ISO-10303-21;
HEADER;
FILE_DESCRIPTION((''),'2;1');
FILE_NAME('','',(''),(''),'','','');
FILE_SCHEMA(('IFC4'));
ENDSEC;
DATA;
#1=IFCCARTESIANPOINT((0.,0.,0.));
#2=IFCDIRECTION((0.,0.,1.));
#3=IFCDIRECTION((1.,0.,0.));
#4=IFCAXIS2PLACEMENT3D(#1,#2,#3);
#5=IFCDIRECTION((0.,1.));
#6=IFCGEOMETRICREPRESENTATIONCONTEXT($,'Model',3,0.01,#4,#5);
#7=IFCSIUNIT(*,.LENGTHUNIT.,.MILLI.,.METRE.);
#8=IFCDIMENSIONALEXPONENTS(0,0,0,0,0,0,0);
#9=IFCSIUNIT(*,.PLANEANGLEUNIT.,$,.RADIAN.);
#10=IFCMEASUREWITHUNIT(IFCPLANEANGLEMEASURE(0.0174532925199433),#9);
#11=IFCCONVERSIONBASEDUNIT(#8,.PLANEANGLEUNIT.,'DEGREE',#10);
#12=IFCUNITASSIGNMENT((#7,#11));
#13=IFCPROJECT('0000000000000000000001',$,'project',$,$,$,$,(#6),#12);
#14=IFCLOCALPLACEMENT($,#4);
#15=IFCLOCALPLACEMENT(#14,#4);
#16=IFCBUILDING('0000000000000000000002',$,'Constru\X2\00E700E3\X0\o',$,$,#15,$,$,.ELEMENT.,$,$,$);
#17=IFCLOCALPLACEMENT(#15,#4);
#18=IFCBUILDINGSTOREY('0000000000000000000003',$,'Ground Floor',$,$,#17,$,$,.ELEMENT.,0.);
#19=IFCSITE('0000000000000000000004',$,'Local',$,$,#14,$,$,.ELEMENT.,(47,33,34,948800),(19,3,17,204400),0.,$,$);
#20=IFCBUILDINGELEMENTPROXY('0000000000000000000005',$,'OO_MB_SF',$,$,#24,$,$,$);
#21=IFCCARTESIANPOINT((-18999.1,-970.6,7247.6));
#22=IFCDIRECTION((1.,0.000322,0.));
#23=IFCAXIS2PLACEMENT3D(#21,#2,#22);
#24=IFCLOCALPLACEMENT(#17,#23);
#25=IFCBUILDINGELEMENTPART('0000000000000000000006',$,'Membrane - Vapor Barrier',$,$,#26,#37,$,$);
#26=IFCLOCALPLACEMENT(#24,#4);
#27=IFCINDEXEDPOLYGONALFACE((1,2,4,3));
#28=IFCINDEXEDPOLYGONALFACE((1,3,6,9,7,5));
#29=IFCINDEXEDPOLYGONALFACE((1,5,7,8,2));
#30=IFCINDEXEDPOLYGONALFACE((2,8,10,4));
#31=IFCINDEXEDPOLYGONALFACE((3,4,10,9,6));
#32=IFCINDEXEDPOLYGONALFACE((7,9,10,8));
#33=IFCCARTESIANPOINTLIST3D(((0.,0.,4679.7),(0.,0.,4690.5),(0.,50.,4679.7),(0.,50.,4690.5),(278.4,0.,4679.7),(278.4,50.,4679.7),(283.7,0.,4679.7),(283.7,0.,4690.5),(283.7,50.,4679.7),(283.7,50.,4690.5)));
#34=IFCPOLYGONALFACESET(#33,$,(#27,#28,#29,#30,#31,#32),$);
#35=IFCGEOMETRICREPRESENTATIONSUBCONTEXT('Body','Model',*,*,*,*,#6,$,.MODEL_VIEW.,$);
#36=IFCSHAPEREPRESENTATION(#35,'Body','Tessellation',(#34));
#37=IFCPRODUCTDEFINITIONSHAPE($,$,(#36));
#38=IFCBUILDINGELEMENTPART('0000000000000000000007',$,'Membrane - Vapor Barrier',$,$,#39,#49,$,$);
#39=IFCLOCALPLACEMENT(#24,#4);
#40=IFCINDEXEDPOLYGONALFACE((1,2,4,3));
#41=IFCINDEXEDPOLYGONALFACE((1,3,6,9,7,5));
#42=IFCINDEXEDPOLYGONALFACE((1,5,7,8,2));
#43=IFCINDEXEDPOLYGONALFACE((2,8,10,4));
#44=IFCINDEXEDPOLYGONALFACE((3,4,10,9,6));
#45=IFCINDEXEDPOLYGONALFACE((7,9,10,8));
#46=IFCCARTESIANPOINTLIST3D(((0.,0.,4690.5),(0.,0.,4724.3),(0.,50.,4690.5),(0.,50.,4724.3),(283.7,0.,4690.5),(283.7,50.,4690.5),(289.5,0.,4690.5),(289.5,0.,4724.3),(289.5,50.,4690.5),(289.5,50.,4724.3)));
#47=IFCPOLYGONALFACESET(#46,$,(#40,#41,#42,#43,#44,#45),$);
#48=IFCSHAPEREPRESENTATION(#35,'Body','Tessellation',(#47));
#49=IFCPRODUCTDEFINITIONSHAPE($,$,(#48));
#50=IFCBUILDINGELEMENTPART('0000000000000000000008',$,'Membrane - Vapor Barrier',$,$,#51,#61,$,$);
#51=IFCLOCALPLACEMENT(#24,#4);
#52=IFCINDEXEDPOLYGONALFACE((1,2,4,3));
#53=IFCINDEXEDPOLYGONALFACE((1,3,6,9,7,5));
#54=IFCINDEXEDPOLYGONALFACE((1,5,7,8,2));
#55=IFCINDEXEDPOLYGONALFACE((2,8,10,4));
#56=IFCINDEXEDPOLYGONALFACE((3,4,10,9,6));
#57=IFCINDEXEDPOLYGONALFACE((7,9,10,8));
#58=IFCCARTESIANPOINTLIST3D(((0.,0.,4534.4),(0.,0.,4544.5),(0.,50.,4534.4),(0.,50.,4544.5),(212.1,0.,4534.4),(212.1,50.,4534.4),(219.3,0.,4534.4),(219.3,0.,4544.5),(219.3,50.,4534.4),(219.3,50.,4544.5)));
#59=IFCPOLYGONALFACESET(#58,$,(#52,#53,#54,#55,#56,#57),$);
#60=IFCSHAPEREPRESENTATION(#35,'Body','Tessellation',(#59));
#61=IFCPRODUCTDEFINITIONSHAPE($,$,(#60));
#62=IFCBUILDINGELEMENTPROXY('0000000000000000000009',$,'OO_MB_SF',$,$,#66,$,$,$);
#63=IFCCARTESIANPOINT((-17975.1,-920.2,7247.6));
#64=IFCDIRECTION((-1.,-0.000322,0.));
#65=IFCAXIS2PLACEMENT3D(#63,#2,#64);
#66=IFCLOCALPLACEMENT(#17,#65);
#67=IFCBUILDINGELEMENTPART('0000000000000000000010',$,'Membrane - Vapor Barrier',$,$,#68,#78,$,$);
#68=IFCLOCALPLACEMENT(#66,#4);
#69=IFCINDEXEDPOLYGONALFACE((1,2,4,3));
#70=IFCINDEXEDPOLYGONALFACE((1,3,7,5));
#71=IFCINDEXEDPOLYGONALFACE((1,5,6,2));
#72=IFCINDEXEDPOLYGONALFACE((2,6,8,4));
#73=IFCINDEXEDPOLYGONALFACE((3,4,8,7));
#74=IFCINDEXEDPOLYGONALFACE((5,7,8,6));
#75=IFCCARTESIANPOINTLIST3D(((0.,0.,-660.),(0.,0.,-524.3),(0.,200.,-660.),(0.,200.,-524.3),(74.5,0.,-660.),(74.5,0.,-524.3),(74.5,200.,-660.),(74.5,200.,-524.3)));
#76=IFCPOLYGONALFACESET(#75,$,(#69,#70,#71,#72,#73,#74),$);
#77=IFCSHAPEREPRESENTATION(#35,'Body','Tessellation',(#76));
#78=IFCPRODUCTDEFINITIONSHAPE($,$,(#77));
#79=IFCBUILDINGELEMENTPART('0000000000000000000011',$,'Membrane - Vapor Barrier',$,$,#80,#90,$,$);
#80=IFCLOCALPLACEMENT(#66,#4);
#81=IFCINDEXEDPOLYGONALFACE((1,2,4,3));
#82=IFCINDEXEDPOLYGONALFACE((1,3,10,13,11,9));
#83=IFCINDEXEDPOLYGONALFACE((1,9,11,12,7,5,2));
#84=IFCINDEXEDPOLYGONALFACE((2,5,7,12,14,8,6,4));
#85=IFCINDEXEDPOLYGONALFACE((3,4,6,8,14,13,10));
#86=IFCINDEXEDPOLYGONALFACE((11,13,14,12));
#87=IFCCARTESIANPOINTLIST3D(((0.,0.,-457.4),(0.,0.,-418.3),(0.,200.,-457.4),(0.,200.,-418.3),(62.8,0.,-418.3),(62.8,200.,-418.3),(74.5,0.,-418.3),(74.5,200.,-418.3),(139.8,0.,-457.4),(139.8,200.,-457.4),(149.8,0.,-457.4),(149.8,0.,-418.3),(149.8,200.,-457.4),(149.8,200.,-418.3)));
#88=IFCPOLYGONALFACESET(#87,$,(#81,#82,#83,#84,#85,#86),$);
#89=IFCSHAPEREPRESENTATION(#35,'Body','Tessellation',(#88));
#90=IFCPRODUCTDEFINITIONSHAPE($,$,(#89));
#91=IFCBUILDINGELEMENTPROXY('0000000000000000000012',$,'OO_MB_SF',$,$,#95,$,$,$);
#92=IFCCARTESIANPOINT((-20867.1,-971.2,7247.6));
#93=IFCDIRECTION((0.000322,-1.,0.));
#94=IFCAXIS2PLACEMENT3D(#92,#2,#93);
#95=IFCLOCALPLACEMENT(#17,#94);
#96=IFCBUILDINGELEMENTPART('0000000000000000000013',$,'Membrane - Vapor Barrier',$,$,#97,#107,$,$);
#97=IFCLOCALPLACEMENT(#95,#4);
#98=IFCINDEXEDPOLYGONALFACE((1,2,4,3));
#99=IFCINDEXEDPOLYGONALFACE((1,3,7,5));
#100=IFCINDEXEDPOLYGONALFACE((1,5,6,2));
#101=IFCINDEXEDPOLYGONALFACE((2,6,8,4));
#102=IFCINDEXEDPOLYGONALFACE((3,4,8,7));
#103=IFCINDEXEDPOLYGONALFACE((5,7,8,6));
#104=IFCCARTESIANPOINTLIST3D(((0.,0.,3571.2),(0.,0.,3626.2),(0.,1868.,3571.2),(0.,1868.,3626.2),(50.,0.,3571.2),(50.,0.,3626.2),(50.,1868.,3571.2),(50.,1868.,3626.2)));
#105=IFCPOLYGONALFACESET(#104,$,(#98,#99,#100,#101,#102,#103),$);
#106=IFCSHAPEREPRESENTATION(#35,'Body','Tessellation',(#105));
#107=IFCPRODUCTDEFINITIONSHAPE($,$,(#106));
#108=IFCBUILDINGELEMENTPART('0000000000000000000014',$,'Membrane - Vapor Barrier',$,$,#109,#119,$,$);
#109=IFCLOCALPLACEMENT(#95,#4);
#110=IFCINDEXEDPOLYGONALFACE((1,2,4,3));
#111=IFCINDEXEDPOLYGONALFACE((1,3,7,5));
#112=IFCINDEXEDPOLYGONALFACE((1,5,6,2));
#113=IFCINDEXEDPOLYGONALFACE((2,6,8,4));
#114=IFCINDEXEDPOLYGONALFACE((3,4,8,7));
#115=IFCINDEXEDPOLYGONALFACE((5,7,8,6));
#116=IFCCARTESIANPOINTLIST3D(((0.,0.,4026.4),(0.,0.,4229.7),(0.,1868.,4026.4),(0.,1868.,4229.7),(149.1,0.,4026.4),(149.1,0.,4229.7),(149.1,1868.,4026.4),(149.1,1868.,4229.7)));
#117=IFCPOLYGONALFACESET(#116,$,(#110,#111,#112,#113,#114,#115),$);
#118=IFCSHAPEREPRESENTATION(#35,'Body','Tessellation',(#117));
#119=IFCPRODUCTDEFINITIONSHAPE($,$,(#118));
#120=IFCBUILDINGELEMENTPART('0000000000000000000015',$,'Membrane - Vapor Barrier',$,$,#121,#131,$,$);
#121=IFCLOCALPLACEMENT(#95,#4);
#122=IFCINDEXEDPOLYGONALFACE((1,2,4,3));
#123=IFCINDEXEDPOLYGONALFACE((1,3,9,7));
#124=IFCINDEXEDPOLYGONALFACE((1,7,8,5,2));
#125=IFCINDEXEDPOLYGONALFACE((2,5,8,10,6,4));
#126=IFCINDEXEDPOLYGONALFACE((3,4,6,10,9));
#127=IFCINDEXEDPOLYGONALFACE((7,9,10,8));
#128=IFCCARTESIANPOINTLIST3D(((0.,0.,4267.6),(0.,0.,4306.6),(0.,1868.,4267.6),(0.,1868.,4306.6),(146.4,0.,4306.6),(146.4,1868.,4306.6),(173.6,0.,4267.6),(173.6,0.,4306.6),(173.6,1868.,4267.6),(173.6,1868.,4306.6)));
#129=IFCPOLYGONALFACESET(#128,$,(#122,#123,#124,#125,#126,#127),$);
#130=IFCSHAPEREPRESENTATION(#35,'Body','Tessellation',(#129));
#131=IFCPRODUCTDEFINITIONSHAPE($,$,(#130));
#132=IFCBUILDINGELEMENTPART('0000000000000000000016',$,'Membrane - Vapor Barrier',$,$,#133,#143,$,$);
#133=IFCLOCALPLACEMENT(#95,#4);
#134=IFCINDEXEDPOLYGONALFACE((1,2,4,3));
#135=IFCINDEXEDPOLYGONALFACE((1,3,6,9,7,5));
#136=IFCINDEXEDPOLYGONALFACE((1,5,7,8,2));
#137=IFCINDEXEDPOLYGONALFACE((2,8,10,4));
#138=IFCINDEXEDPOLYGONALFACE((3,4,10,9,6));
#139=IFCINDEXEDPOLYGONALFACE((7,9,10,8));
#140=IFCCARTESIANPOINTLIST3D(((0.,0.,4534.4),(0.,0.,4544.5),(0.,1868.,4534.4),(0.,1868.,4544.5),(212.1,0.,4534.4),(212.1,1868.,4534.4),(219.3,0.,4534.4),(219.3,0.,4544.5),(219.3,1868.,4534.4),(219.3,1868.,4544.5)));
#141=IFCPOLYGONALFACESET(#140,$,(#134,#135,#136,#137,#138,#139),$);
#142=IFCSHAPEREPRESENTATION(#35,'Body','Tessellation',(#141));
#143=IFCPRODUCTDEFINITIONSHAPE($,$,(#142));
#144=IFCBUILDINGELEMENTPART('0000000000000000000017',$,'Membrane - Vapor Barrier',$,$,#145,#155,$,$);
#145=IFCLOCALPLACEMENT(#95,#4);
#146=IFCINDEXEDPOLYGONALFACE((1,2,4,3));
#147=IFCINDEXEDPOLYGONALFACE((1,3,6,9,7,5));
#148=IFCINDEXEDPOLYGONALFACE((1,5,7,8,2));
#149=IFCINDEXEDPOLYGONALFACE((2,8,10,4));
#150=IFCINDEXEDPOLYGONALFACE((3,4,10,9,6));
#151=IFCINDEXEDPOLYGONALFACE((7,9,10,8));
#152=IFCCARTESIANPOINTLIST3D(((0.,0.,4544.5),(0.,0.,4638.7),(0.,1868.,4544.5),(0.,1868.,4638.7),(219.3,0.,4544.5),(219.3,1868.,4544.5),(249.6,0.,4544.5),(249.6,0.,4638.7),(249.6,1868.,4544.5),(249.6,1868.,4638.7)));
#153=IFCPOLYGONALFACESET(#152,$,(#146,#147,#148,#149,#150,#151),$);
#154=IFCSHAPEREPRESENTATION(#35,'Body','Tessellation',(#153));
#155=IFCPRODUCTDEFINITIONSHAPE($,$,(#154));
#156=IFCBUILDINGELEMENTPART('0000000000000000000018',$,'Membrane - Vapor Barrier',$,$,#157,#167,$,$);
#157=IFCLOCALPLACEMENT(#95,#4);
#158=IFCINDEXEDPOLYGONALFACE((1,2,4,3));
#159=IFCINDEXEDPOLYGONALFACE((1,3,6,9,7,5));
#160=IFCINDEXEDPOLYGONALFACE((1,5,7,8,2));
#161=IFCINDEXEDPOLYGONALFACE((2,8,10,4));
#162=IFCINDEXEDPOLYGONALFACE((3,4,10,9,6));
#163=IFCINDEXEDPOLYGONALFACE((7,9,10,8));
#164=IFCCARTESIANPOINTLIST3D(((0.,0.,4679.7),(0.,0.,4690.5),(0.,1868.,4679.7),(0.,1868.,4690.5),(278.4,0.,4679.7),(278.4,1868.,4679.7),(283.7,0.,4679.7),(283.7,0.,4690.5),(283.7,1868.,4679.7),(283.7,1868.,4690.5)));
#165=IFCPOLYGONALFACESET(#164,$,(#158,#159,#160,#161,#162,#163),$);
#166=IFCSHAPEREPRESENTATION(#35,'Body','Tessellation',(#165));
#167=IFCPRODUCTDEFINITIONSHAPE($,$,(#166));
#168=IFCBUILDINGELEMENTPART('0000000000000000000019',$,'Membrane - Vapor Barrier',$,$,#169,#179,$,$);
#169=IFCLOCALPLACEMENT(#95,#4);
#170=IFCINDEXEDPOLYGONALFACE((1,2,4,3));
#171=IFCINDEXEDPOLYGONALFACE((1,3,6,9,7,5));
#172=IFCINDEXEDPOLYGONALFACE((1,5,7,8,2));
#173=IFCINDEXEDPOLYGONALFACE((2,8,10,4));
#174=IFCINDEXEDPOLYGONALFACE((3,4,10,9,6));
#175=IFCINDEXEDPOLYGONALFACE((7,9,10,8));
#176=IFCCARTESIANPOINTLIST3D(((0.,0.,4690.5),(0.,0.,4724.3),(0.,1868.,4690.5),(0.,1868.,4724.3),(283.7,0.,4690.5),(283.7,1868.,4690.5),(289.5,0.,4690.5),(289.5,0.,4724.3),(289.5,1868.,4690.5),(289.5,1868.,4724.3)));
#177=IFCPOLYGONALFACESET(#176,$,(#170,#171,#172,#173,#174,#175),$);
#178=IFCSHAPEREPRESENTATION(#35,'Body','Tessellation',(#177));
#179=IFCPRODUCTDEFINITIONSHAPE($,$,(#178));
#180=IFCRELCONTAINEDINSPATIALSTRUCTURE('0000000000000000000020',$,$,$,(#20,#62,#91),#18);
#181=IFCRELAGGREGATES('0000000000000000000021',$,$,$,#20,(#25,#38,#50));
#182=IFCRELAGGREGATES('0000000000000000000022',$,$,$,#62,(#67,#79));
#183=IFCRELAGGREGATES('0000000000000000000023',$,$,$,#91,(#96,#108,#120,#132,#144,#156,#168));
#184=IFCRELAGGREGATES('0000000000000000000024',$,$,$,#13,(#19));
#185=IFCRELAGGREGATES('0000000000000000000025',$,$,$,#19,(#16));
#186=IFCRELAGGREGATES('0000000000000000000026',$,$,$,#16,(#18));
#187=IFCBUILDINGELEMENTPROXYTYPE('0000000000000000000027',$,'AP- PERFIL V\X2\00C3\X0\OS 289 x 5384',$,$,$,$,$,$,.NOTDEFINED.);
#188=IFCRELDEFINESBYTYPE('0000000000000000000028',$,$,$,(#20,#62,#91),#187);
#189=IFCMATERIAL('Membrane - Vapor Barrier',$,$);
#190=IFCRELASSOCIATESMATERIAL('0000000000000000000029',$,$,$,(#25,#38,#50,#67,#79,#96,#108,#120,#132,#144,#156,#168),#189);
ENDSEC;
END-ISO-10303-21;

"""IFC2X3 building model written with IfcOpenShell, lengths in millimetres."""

from ifc_helpers import new_model, entity, si_unit, converted_unit, direction, frame, origin_with_axes, place, context, subcontext, project, spatial, polyline, outline, extrude, material, type_object, element, aggregate, save


model = new_model("IFC2X3")

# Units and contexts
model_context = context("Model", 3, precision=0.01, world=origin_with_axes(), true_north=direction((0.0, 1.0)))
body_context = subcontext(model_context, "Body", "Model", "MODEL_VIEW")
ifc_project = project(units=[si_unit("LENGTHUNIT", "METRE", prefix="MILLI"), converted_unit("PLANEANGLEUNIT", "DEGREE", entity("IfcPlaneAngleMeasure", 0.0174532925199433), si_unit("PLANEANGLEUNIT", "RADIAN"), dimensions=[0, 0, 0, 0, 0, 0, 0])], contexts=[model_context])

# Site, building, storey
site_placement = place(None, origin_with_axes())
site = spatial("IfcSite", under=ifc_project, at=site_placement, Name="Local", CompositionType="ELEMENT", RefLatitude=(47, 33, 34, 948800), RefLongitude=(19, 3, 17, 204400), RefElevation=0.0)
building_placement = place(site_placement, origin_with_axes())
building = spatial("IfcBuilding", under=site, at=building_placement, Name="Construção", CompositionType="ELEMENT")
storey_placement = place(building_placement, origin_with_axes())
storey = spatial("IfcBuildingStorey", under=building, at=storey_placement, Name="Ground Floor", CompositionType="ELEMENT", Elevation=0.0)

# Building element proxies, building element parts
building_element_proxy_type = type_object("IfcBuildingElementProxyType", Name="AP- PERFIL VÃOS 289 x 5384", PredefinedType="NOTDEFINED")
proxy_1_placement = place(storey_placement, frame((-18999.1, -970.6, 7247.6), z_axis=(0.0, 0.0, 1.0), x_axis=(1.0, 0.000322, 0.0)))
proxy_1 = element("IfcBuildingElementProxy", 1, at=proxy_1_placement, inside=storey, type_object=building_element_proxy_type, Name="OO_MB_SF")
ifc_material = material(Name="Membrane - Vapor Barrier")
building_element_part_1_placement = place(proxy_1_placement, origin_with_axes())
building_element_part_1 = element("IfcBuildingElementPart", 2, at=building_element_part_1_placement, material=ifc_material, Name="Membrane - Vapor Barrier", context=body_context, shape_type="SweptSolid", body=[
    extrude(outline(polyline([(0.0, 4679.7), (278.4, 4679.7), (283.7, 4679.7), (283.7, 4690.5), (0.0, 4690.5), (0.0, 4679.7)])), frame((0.0, 50.0, 0.0), z_axis=(0.0, -1.0, 0.0), x_axis=(1.0, 0.0, 0.0)), (0.0, 0.0, 1.0), 50.0),
])
building_element_part_2_placement = place(proxy_1_placement, origin_with_axes())
building_element_part_2 = element("IfcBuildingElementPart", 3, at=building_element_part_2_placement, material=ifc_material, Name="Membrane - Vapor Barrier", context=body_context, shape_type="SweptSolid", body=[
    extrude(outline(polyline([(0.0, 4690.5), (283.7, 4690.5), (289.5, 4690.5), (289.5, 4724.3), (0.0, 4724.3), (0.0, 4690.5)])), frame((0.0, 50.0, 0.0), z_axis=(0.0, -1.0, 0.0), x_axis=(1.0, 0.0, 0.0)), (0.0, 0.0, 1.0), 50.0),
])
building_element_part_3_placement = place(proxy_1_placement, origin_with_axes())
building_element_part_3 = element("IfcBuildingElementPart", 4, at=building_element_part_3_placement, material=ifc_material, Name="Membrane - Vapor Barrier", context=body_context, shape_type="SweptSolid", body=[
    extrude(outline(polyline([(0.0, 4534.4), (212.1, 4534.4), (219.3, 4534.4), (219.3, 4544.5), (0.0, 4544.5), (0.0, 4534.4)])), frame((0.0, 50.0, 0.0), z_axis=(0.0, -1.0, 0.0), x_axis=(1.0, 0.0, 0.0)), (0.0, 0.0, 1.0), 50.0),
])
aggregate(proxy_1, [building_element_part_1, building_element_part_2, building_element_part_3])
proxy_2_placement = place(storey_placement, frame((-17975.1, -920.2, 7247.6), z_axis=(0.0, 0.0, 1.0), x_axis=(-1.0, -0.000322, 0.0)))
proxy_2 = element("IfcBuildingElementProxy", 5, at=proxy_2_placement, inside=storey, type_object=building_element_proxy_type, Name="OO_MB_SF")
building_element_part_4_placement = place(proxy_2_placement, origin_with_axes())
building_element_part_4 = element("IfcBuildingElementPart", 6, at=building_element_part_4_placement, material=ifc_material, Name="Membrane - Vapor Barrier", context=body_context, shape_type="SweptSolid", body=[
    extrude(outline(polyline([(0.0, -660.0), (74.5, -660.0), (74.5, -524.3), (0.0, -524.3), (0.0, -660.0)])), frame((0.0, 200.0, 0.0), z_axis=(0.0, -1.0, 0.0), x_axis=(1.0, 0.0, 0.0)), (0.0, 0.0, 1.0), 200.0),
])
building_element_part_5_placement = place(proxy_2_placement, origin_with_axes())
building_element_part_5 = element("IfcBuildingElementPart", 7, at=building_element_part_5_placement, material=ifc_material, Name="Membrane - Vapor Barrier", context=body_context, shape_type="SweptSolid", body=[
    extrude(outline(polyline([(62.8, -418.3), (0.0, -418.3), (0.0, -457.4), (139.8, -457.4), (149.8, -457.4), (149.8, -418.3), (74.5, -418.3), (62.8, -418.3)])), frame((0.0, 200.0, 0.0), z_axis=(0.0, -1.0, 0.0), x_axis=(1.0, 0.0, 0.0)), (0.0, 0.0, 1.0), 200.0),
])
aggregate(proxy_2, [building_element_part_4, building_element_part_5])
proxy_3_placement = place(storey_placement, frame((-20867.1, -971.2, 7247.6), z_axis=(0.0, 0.0, 1.0), x_axis=(0.000322, -1.0, 0.0)))
proxy_3 = element("IfcBuildingElementProxy", 8, at=proxy_3_placement, inside=storey, type_object=building_element_proxy_type, Name="OO_MB_SF")
building_element_part_6_placement = place(proxy_3_placement, origin_with_axes())
building_element_part_6 = element("IfcBuildingElementPart", 9, at=building_element_part_6_placement, material=ifc_material, Name="Membrane - Vapor Barrier", context=body_context, shape_type="SweptSolid", body=[
    extrude(outline(polyline([(0.0, 3571.2), (50.0, 3571.2), (50.0, 3626.2), (0.0, 3626.2), (0.0, 3571.2)])), frame((0.0, 1868.0, 0.0), z_axis=(0.0, -1.0, 0.0), x_axis=(1.0, 0.0, 0.0)), (0.0, 0.0, 1.0), 1868.0),
])
building_element_part_7_placement = place(proxy_3_placement, origin_with_axes())
building_element_part_7 = element("IfcBuildingElementPart", 10, at=building_element_part_7_placement, material=ifc_material, Name="Membrane - Vapor Barrier", context=body_context, shape_type="SweptSolid", body=[
    extrude(outline(polyline([(149.1, 4229.7), (0.0, 4229.7), (0.0, 4026.4), (149.1, 4026.4), (149.1, 4229.7)])), frame((0.0, 1868.0, 0.0), z_axis=(0.0, -1.0, 0.0), x_axis=(1.0, 0.0, 0.0)), (0.0, 0.0, 1.0), 1868.0),
])
building_element_part_8_placement = place(proxy_3_placement, origin_with_axes())
building_element_part_8 = element("IfcBuildingElementPart", 11, at=building_element_part_8_placement, material=ifc_material, Name="Membrane - Vapor Barrier", context=body_context, shape_type="SweptSolid", body=[
    extrude(outline(polyline([(0.0, 4306.6), (0.0, 4267.6), (173.6, 4267.6), (173.6, 4306.6), (146.4, 4306.6), (0.0, 4306.6)])), frame((0.0, 1868.0, 0.0), z_axis=(0.0, -1.0, 0.0), x_axis=(1.0, 0.0, 0.0)), (0.0, 0.0, 1.0), 1868.0),
])
building_element_part_9_placement = place(proxy_3_placement, origin_with_axes())
building_element_part_9 = element("IfcBuildingElementPart", 12, at=building_element_part_9_placement, material=ifc_material, Name="Membrane - Vapor Barrier", context=body_context, shape_type="SweptSolid", body=[
    extrude(outline(polyline([(0.0, 4534.4), (212.1, 4534.4), (219.3, 4534.4), (219.3, 4544.5), (0.0, 4544.5), (0.0, 4534.4)])), frame((0.0, 1868.0, 0.0), z_axis=(0.0, -1.0, 0.0), x_axis=(1.0, 0.0, 0.0)), (0.0, 0.0, 1.0), 1868.0),
])
building_element_part_10_placement = place(proxy_3_placement, origin_with_axes())
building_element_part_10 = element("IfcBuildingElementPart", 13, at=building_element_part_10_placement, material=ifc_material, Name="Membrane - Vapor Barrier", context=body_context, shape_type="SweptSolid", body=[
    extrude(outline(polyline([(249.6, 4638.7), (0.0, 4638.7), (0.0, 4544.5), (219.3, 4544.5), (249.6, 4544.5), (249.6, 4638.7)])), frame((0.0, 1868.0, 0.0), z_axis=(0.0, -1.0, 0.0), x_axis=(1.0, 0.0, 0.0)), (0.0, 0.0, 1.0), 1868.0),
])
building_element_part_11_placement = place(proxy_3_placement, origin_with_axes())
building_element_part_11 = element("IfcBuildingElementPart", 14, at=building_element_part_11_placement, material=ifc_material, Name="Membrane - Vapor Barrier", context=body_context, shape_type="SweptSolid", body=[
    extrude(outline(polyline([(0.0, 4679.7), (278.4, 4679.7), (283.7, 4679.7), (283.7, 4690.5), (0.0, 4690.5), (0.0, 4679.7)])), frame((0.0, 1868.0, 0.0), z_axis=(0.0, -1.0, 0.0), x_axis=(1.0, 0.0, 0.0)), (0.0, 0.0, 1.0), 1868.0),
])
building_element_part_12_placement = place(proxy_3_placement, origin_with_axes())
building_element_part_12 = element("IfcBuildingElementPart", 15, at=building_element_part_12_placement, material=ifc_material, Name="Membrane - Vapor Barrier", context=body_context, shape_type="SweptSolid", body=[
    extrude(outline(polyline([(0.0, 4690.5), (283.7, 4690.5), (289.5, 4690.5), (289.5, 4724.3), (0.0, 4724.3), (0.0, 4690.5)])), frame((0.0, 1868.0, 0.0), z_axis=(0.0, -1.0, 0.0), x_axis=(1.0, 0.0, 0.0)), (0.0, 0.0, 1.0), 1868.0),
])
aggregate(proxy_3, [building_element_part_6, building_element_part_7, building_element_part_8, building_element_part_9, building_element_part_10, building_element_part_11, building_element_part_12])

save(model, "model.ifc")
